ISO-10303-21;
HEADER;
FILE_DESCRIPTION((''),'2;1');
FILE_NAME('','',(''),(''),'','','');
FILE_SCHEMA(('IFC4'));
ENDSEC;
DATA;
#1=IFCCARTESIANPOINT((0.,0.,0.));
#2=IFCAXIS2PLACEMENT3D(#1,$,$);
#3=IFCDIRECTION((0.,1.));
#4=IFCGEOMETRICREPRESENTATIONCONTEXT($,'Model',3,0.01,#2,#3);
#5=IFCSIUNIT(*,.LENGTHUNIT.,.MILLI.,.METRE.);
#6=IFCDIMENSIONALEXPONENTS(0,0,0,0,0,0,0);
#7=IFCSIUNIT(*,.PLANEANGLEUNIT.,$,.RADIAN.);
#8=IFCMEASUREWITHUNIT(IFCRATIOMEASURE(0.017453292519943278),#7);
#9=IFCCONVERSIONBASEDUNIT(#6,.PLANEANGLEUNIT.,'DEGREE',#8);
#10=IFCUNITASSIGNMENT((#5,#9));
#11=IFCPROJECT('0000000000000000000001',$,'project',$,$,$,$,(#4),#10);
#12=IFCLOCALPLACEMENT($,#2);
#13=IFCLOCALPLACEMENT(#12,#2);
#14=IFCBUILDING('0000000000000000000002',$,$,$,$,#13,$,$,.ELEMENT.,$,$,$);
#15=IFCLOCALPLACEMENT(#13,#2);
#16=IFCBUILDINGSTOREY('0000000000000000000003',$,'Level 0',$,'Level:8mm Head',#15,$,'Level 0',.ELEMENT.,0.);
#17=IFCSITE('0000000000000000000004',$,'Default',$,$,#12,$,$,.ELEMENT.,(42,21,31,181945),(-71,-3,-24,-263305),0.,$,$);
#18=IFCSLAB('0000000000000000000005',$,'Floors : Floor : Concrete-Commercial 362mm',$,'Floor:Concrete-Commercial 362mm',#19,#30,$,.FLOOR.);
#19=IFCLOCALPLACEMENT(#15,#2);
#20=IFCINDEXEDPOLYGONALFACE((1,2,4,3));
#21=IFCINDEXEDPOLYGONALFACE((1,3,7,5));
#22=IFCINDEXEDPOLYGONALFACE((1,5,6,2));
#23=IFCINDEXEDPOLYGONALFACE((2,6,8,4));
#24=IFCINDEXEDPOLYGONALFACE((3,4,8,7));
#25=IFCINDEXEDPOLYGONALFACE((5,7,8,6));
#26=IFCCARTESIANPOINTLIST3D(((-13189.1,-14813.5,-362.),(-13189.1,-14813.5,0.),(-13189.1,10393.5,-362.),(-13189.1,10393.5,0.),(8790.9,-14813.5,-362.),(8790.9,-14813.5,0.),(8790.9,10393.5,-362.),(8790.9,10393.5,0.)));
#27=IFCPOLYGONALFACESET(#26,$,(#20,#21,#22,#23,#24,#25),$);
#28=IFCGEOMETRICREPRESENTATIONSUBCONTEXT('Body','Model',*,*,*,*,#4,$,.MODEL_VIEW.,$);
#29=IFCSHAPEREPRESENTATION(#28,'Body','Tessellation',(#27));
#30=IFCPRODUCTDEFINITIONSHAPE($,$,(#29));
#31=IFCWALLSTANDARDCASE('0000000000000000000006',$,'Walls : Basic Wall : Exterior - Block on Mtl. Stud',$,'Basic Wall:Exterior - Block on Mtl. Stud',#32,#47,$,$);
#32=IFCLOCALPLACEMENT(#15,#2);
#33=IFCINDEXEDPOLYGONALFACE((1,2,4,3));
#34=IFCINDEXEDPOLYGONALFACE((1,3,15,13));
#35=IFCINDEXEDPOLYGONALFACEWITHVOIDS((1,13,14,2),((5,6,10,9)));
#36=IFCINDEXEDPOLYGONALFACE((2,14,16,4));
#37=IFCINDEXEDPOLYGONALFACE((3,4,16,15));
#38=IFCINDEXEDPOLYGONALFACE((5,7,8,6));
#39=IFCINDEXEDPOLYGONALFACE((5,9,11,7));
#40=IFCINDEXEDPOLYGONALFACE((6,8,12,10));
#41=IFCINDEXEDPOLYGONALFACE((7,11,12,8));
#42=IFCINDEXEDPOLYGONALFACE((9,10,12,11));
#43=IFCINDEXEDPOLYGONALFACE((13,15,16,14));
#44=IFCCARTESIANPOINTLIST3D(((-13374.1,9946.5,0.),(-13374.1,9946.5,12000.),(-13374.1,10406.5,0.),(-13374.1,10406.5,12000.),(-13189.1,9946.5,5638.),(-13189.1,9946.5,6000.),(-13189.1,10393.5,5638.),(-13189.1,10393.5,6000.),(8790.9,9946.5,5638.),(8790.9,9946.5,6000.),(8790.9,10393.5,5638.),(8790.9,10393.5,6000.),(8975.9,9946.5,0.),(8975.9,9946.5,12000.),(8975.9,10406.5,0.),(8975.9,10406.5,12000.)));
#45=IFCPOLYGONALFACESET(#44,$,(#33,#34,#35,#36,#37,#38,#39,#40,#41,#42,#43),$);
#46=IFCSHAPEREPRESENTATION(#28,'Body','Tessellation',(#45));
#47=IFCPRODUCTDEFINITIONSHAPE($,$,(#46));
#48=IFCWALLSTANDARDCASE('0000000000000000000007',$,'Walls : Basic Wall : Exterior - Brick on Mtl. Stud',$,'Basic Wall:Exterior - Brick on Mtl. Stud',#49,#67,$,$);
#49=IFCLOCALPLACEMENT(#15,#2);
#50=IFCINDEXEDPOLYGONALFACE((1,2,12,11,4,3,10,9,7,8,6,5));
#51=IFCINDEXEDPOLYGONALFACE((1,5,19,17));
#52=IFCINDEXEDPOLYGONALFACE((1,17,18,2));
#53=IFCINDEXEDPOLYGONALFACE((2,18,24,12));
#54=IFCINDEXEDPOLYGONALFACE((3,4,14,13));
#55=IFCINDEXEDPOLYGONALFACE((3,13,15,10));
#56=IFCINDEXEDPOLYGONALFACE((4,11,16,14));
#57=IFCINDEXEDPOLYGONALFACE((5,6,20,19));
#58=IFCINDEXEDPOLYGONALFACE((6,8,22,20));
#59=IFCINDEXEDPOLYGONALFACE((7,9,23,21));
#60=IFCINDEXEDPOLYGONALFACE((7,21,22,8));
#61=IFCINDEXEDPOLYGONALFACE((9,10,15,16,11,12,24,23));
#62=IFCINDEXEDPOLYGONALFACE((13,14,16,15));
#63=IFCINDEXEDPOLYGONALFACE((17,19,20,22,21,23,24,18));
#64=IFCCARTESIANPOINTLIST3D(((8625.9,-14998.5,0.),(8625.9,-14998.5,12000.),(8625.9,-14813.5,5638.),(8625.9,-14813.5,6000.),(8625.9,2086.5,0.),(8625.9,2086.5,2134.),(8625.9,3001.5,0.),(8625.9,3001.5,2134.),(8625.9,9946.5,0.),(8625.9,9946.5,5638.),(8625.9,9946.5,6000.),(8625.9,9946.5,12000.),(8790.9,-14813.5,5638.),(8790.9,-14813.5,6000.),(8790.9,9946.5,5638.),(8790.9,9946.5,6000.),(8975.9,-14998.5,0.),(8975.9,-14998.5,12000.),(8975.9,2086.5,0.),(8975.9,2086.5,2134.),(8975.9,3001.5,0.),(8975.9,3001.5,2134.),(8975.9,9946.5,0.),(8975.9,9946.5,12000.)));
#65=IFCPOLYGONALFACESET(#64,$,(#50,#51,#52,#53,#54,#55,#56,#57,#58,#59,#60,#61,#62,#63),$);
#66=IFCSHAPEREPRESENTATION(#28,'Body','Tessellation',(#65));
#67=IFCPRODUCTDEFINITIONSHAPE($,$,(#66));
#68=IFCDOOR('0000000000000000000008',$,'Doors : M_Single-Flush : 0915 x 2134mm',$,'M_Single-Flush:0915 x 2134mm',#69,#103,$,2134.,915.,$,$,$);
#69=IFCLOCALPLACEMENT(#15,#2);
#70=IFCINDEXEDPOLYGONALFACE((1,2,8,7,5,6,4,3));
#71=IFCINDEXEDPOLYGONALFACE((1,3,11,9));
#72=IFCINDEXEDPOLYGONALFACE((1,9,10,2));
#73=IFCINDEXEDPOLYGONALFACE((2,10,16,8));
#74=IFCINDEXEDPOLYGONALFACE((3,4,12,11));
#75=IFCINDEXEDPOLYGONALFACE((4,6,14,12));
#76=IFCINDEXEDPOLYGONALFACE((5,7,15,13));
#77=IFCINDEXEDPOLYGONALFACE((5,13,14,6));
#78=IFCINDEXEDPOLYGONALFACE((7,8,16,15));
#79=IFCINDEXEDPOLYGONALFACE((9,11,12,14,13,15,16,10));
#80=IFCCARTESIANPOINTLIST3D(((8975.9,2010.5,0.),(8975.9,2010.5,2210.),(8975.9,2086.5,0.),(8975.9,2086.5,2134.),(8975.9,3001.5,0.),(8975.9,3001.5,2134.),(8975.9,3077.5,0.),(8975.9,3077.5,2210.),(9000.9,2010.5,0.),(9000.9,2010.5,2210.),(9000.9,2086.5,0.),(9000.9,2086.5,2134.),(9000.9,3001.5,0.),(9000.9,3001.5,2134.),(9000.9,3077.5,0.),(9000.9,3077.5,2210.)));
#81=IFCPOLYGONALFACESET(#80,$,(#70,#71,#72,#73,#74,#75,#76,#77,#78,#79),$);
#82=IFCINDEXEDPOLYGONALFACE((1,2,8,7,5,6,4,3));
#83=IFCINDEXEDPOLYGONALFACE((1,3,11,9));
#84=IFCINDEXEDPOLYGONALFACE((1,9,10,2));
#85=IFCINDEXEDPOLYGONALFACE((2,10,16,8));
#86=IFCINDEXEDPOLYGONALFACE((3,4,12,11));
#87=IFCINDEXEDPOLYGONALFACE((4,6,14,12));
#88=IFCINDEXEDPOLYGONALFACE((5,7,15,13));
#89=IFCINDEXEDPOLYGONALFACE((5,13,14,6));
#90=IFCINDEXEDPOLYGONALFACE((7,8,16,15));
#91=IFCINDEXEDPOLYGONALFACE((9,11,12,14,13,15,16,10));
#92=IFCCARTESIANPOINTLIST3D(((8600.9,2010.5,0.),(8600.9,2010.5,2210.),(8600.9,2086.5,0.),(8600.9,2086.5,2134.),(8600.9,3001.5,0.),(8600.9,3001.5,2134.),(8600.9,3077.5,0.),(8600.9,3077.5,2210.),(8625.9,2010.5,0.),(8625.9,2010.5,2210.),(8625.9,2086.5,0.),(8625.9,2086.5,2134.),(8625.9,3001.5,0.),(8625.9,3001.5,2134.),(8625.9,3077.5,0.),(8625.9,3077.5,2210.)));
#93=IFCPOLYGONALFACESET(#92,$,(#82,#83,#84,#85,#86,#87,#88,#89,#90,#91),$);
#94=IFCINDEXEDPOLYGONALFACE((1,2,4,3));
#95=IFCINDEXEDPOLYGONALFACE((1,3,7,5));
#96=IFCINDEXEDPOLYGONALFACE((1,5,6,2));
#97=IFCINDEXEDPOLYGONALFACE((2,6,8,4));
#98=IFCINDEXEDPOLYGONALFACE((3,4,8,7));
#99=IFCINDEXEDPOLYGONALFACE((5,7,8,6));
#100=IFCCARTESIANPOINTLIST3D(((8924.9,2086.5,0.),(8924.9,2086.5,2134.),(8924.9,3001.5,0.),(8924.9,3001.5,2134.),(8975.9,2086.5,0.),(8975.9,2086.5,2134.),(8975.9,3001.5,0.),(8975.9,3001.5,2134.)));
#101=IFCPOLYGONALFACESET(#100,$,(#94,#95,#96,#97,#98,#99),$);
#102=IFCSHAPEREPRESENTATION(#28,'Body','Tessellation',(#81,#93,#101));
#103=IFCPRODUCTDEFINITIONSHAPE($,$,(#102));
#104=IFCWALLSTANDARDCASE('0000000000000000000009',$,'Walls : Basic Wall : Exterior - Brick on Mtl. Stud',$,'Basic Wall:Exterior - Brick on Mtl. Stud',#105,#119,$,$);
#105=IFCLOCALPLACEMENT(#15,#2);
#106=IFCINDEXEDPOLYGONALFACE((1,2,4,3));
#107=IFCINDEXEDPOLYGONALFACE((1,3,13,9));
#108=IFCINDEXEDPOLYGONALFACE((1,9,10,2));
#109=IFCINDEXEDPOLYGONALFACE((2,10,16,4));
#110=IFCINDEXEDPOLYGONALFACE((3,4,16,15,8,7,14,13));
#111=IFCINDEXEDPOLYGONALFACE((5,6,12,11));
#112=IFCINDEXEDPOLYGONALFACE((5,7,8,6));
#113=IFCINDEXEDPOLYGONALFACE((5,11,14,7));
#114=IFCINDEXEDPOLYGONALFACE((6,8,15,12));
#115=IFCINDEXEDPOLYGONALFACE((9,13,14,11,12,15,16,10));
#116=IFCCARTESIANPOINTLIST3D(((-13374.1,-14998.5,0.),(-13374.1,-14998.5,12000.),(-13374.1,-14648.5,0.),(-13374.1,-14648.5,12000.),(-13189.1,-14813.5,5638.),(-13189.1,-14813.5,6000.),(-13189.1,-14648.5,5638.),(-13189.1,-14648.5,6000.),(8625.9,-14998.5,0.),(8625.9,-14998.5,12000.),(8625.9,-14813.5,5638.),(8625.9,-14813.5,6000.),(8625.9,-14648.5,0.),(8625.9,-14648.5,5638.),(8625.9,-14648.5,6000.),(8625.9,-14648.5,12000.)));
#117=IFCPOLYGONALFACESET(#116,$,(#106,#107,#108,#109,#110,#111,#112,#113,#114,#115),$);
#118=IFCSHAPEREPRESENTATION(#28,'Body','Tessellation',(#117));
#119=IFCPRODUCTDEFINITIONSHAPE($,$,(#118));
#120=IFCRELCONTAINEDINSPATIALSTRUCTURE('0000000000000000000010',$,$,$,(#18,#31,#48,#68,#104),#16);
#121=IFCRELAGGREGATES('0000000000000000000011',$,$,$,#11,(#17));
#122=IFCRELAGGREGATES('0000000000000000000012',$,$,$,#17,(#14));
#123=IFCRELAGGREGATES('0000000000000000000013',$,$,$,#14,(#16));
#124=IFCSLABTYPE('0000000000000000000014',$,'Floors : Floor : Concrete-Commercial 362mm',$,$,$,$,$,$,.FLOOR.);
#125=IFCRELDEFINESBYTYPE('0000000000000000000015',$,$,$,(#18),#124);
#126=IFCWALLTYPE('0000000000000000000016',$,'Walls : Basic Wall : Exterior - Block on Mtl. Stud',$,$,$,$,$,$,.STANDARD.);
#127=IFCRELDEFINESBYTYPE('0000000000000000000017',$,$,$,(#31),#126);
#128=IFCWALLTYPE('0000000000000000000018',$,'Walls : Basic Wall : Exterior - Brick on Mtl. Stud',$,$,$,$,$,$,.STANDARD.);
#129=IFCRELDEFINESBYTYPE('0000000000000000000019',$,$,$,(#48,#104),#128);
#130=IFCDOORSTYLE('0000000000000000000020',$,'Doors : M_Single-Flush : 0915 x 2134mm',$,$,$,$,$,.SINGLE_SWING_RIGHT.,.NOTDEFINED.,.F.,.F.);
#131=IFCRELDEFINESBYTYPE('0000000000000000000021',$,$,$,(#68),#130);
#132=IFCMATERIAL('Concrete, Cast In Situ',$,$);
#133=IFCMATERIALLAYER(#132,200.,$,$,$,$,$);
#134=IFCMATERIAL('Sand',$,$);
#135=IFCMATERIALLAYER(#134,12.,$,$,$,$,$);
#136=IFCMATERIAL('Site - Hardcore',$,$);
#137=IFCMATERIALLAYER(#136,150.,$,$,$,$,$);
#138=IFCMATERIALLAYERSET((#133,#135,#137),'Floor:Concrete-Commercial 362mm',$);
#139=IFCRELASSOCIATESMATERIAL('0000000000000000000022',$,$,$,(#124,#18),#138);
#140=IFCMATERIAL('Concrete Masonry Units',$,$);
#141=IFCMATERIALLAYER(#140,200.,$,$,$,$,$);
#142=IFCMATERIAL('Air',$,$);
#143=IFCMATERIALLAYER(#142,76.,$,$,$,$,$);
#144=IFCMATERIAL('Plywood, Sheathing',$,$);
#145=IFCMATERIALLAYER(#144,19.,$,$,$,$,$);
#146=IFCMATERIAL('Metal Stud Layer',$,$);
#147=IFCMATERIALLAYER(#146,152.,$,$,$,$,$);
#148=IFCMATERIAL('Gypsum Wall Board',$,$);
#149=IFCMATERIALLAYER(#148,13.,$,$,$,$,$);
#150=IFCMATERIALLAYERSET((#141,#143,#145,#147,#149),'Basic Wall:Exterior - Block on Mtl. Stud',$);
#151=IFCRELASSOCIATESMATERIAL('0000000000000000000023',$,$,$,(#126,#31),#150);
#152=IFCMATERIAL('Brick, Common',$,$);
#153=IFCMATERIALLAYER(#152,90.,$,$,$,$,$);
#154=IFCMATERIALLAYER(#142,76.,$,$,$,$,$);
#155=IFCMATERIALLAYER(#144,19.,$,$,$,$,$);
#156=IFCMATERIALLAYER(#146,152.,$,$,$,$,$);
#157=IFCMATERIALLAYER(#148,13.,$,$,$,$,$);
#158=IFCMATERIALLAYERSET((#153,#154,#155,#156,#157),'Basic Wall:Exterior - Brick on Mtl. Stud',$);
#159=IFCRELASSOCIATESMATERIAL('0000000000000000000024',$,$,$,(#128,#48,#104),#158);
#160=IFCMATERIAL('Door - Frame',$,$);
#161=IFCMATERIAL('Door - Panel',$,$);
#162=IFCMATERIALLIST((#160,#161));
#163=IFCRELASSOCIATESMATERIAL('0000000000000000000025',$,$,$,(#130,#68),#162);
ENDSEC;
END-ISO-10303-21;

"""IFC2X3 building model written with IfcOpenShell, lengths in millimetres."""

from ifc_helpers import new_model, entity, si_unit, converted_unit, direction, frame, frame_2d, origin, place, context, subcontext, project, spatial, polyline, rectangle, outline, extrude, source, transform, mapped, material, material_list, layer, layer_set, layer_usage, type_object, type_shapes, element, fill, save


model = new_model("IFC2X3")

# Units and contexts
model_context = context("Model", 3, precision=0.01, world=origin(), true_north=direction((0.0, 1.0)))
body_context = subcontext(model_context, "Body", "Model", "MODEL_VIEW")
ifc_project = project(units=[si_unit("LENGTHUNIT", "METRE", prefix="MILLI"), converted_unit("PLANEANGLEUNIT", "DEGREE", entity("IfcRatioMeasure", 0.017453292519943278), si_unit("PLANEANGLEUNIT", "RADIAN"), dimensions=[0, 0, 0, 0, 0, 0, 0])], contexts=[model_context])

# Site, building, storey
site_placement = place(None, origin())
site = spatial("IfcSite", under=ifc_project, at=site_placement, Name="Default", CompositionType="ELEMENT", RefLatitude=(42, 21, 31, 181945), RefLongitude=(-71, -3, -24, -263305), RefElevation=0.0)
building_placement = place(site_placement, origin())
building = spatial("IfcBuilding", under=site, at=building_placement, CompositionType="ELEMENT")
storey_placement = place(building_placement, origin())
storey = spatial("IfcBuildingStorey", under=building, at=storey_placement, Name="Level 0", ObjectType="Level:8mm Head", LongName="Level 0", CompositionType="ELEMENT", Elevation=0.0)

# Slab
ifc_material_1 = material(Name="Concrete, Cast In Situ")
ifc_layer_1 = layer(ifc_material_1, 200.0)
ifc_material_2 = material(Name="Sand")
ifc_layer_2 = layer(ifc_material_2, 12.0)
ifc_material_3 = material(Name="Site - Hardcore")
ifc_layer_3 = layer(ifc_material_3, 150.0)
ifc_layer_set_1 = layer_set([ifc_layer_1, ifc_layer_2, ifc_layer_3], Name="Floor:Concrete-Commercial 362mm")
ifc_layer_usage_1 = layer_usage(ifc_layer_set_1, "AXIS3", "POSITIVE", 0.0)
slab_type = type_object("IfcSlabType", Name="Floors : Floor : Concrete-Commercial 362mm", PredefinedType="FLOOR", material=ifc_layer_set_1)
slab_placement = place(storey_placement, origin())
element("IfcSlab", 1, at=slab_placement, inside=storey, type_object=slab_type, material=ifc_layer_usage_1, Name="Floors : Floor : Concrete-Commercial 362mm", ObjectType="Floor:Concrete-Commercial 362mm", PredefinedType="FLOOR", context=body_context, shape_type="SweptSolid", body=[
    extrude(rectangle(XDim=25207.0, YDim=21980.0, at=frame_2d((0.0, 0.0), x_axis=(1.0, 0.0))), frame((-2199.1, -2210.0, 0.0), z_axis=(0.0, 0.0, -1.0), x_axis=(0.0, 1.0, 0.0)), (0.0, 0.0, 1.0), 362.0),
])

# Wall, opening
ifc_material_4 = material(Name="Concrete Masonry Units")
ifc_layer_4 = layer(ifc_material_4, 200.0)
ifc_material_5 = material(Name="Air")
ifc_layer_5 = layer(ifc_material_5, 76.0)
ifc_material_6 = material(Name="Plywood, Sheathing")
ifc_layer_6 = layer(ifc_material_6, 19.0)
ifc_material_7 = material(Name="Metal Stud Layer")
ifc_layer_7 = layer(ifc_material_7, 152.0)
ifc_material_8 = material(Name="Gypsum Wall Board")
ifc_layer_8 = layer(ifc_material_8, 13.0)
ifc_layer_set_2 = layer_set([ifc_layer_4, ifc_layer_5, ifc_layer_6, ifc_layer_7, ifc_layer_8], Name="Basic Wall:Exterior - Block on Mtl. Stud")
ifc_layer_usage_2 = layer_usage(ifc_layer_set_2, "AXIS2", "POSITIVE", -230.0)
wall_type_1 = type_object("IfcWallType", Name="Walls : Basic Wall : Exterior - Block on Mtl. Stud", PredefinedType="STANDARD", material=ifc_layer_set_2)
wall_1_placement = place(storey_placement, frame((-13374.1, 10176.5, 0.0)))
wall_1 = element("IfcWallStandardCase", 2, at=wall_1_placement, inside=storey, type_object=wall_type_1, material=ifc_layer_usage_2, Name="Walls : Basic Wall : Exterior - Block on Mtl. Stud", ObjectType="Basic Wall:Exterior - Block on Mtl. Stud", context=body_context, shape_type="SweptSolid", body=[
    extrude(rectangle(XDim=22350.0, YDim=460.0, at=frame_2d((11175.0, 0.0), x_axis=(-1.0, 0.0))), origin(), (0.0, 0.0, 1.0), 12000.0),
])
opening_1_placement = place(storey_placement, frame((-13374.1, 10176.5, 0.0)))
element("IfcOpeningElement", 3, at=opening_1_placement, cuts=wall_1, ObjectType="Opening", context=body_context, shape_type="SweptSolid", body=[
    extrude(rectangle(XDim=21980.0, YDim=447.0, at=frame_2d((0.0, -111.7), x_axis=(1.0, 0.0))), frame((11175.0, -118.2, 5638.0), z_axis=(0.0, 0.0, 1.0), x_axis=(-1.0, 0.0, 0.0)), (0.0, 0.0, 1.0), 362.0),
])

# Wall, openings, door
ifc_material_9 = material(Name="Brick, Common")
ifc_layer_9 = layer(ifc_material_9, 90.0)
ifc_layer_10 = layer(ifc_material_5, 76.0)
ifc_layer_11 = layer(ifc_material_6, 19.0)
ifc_layer_12 = layer(ifc_material_7, 152.0)
ifc_layer_13 = layer(ifc_material_8, 13.0)
ifc_layer_set_3 = layer_set([ifc_layer_9, ifc_layer_10, ifc_layer_11, ifc_layer_12, ifc_layer_13], Name="Basic Wall:Exterior - Brick on Mtl. Stud")
ifc_layer_usage_3 = layer_usage(ifc_layer_set_3, "AXIS2", "NEGATIVE", 175.0)
wall_type_2 = type_object("IfcWallType", Name="Walls : Basic Wall : Exterior - Brick on Mtl. Stud", PredefinedType="STANDARD", material=ifc_layer_set_3)
wall_2_placement = place(storey_placement, frame((8800.9, 9946.5, 0.0), z_axis=(0.0, 0.0, 1.0), x_axis=(0.0, -1.0, 0.0)))
wall_2 = element("IfcWallStandardCase", 4, at=wall_2_placement, inside=storey, type_object=wall_type_2, material=ifc_layer_usage_3, Name="Walls : Basic Wall : Exterior - Brick on Mtl. Stud", ObjectType="Basic Wall:Exterior - Brick on Mtl. Stud", context=body_context, shape_type="SweptSolid", body=[
    extrude(rectangle(XDim=24945.0, YDim=350.0, at=frame_2d((12472.5, 0.0), x_axis=(-1.0, 0.0))), origin(), (0.0, 0.0, 1.0), 12000.0),
])
opening_2_placement = place(storey_placement, frame((8800.9, 9946.5, 0.0), z_axis=(0.0, 0.0, 1.0), x_axis=(0.0, -1.0, 0.0)))
element("IfcOpeningElement", 5, at=opening_2_placement, cuts=wall_2, ObjectType="Opening", context=body_context, shape_type="SweptSolid", body=[
    extrude(rectangle(XDim=165.0, YDim=24760.0, at=frame_2d((33.5, 1723.3), x_axis=(1.0, 0.0))), frame((14103.3, -126.0, 5638.0), z_axis=(0.0, 0.0, 1.0), x_axis=(0.0, 1.0, 0.0)), (0.0, 0.0, 1.0), 362.0),
])
opening_3_placement = place(wall_2_placement, frame((6945.0, -175.0, 0.0)))
opening_3 = element("IfcOpeningElement", 6, at=opening_3_placement, cuts=wall_2, ObjectType="Opening", context=body_context, shape_type="SweptSolid", body=[
    extrude(rectangle(XDim=915.0, YDim=2134.0, at=frame_2d((1067.0, 457.5), x_axis=(0.0, 1.0))), frame((0.0, 0.0, 0.0), z_axis=(0.0, 1.0, 0.0), x_axis=(0.0, 0.0, 1.0)), (0.0, 0.0, 1.0), 350.0),
])
ifc_material_10 = material(Name="Door - Frame")
ifc_material_11 = material(Name="Door - Panel")
ifc_material_list = material_list([ifc_material_10, ifc_material_11])
door_style_1 = type_object("IfcDoorStyle", Name="Doors : M_Single-Flush : 0915 x 2134mm", ConstructionType="NOTDEFINED", OperationType="SINGLE_SWING_RIGHT", ParameterTakesPrecedence=False, Sizeable=False, material=ifc_material_list)
shared_shape_1 = source(origin(), body_context, "Body", "SweptSolid", [
    extrude(outline(polyline([(-533.5, -1124.0), (533.5, -1124.0), (533.5, 1086.0), (457.5, 1086.0), (457.5, -1048.0), (-457.5, -1048.0), (-457.5, 1086.0), (-533.5, 1086.0), (-533.5, -1124.0)])), frame((457.5, 350.0, 1086.0), z_axis=(0.0, 1.0, 0.0), x_axis=(1.0, 0.0, 0.0)), (0.0, 0.0, 1.0), 25.0),
    extrude(outline(polyline([(-1124.0, -533.5), (1086.0, -533.5), (1086.0, -457.5), (-1048.0, -457.5), (-1048.0, 457.5), (1086.0, 457.5), (1086.0, 533.5), (-1124.0, 533.5), (-1124.0, -533.5)])), frame((457.5, -25.0, 1086.0), z_axis=(0.0, 1.0, 0.0), x_axis=(0.0, 0.0, -1.0)), (0.0, 0.0, 1.0), 25.0),
    extrude(rectangle(XDim=51.0, YDim=915.0, at=frame_2d((0.0, 0.0), x_axis=(1.0, 0.0))), frame((457.5, 324.5, 0.0), z_axis=(0.0, 0.0, 1.0), x_axis=(0.0, 1.0, 0.0)), (0.0, 0.0, 1.0), 2134.0),
])
type_shapes(door_style_1, [shared_shape_1])
door_1_placement = place(opening_3_placement, origin())
door_1 = element("IfcDoor", 7, at=door_1_placement, inside=storey, type_object=door_style_1, material=ifc_material_list, Name="Doors : M_Single-Flush : 0915 x 2134mm", ObjectType="M_Single-Flush:0915 x 2134mm", OverallHeight=2134.0, OverallWidth=915.0, context=body_context, shape_type="MappedRepresentation", body=[
    mapped(shared_shape_1, transform((0.0, 0.0, 0.0), scale=1.0)),
])
fill(opening_3, door_1)

# Wall, opening
wall_3_placement = place(storey_placement, frame((8625.9, -14823.5, 0.0), z_axis=(0.0, 0.0, 1.0), x_axis=(-1.0, 0.0, 0.0)))
wall_3 = element("IfcWallStandardCase", 8, at=wall_3_placement, inside=storey, type_object=wall_type_2, material=ifc_layer_usage_3, Name="Walls : Basic Wall : Exterior - Brick on Mtl. Stud", ObjectType="Basic Wall:Exterior - Brick on Mtl. Stud", context=body_context, shape_type="SweptSolid", body=[
    extrude(rectangle(XDim=22000.0, YDim=350.0, at=frame_2d((11000.0, 0.0), x_axis=(-1.0, 0.0))), origin(), (0.0, 0.0, 1.0), 12000.0),
])
opening_4_placement = place(storey_placement, frame((8625.9, -14823.5, 0.0), z_axis=(0.0, 0.0, 1.0), x_axis=(-1.0, 0.0, 0.0)))
element("IfcOpeningElement", 9, at=opening_4_placement, cuts=wall_3, ObjectType="Opening", context=body_context, shape_type="SweptSolid", body=[
    extrude(rectangle(XDim=165.0, YDim=21815.0, at=frame_2d((44.4, 47.3), x_axis=(1.0, 0.0))), frame((10954.8, -136.9, 5638.0), z_axis=(0.0, 0.0, 1.0), x_axis=(0.0, 1.0, 0.0)), (0.0, 0.0, 1.0), 362.0),
])

save(model, "model.ifc")
